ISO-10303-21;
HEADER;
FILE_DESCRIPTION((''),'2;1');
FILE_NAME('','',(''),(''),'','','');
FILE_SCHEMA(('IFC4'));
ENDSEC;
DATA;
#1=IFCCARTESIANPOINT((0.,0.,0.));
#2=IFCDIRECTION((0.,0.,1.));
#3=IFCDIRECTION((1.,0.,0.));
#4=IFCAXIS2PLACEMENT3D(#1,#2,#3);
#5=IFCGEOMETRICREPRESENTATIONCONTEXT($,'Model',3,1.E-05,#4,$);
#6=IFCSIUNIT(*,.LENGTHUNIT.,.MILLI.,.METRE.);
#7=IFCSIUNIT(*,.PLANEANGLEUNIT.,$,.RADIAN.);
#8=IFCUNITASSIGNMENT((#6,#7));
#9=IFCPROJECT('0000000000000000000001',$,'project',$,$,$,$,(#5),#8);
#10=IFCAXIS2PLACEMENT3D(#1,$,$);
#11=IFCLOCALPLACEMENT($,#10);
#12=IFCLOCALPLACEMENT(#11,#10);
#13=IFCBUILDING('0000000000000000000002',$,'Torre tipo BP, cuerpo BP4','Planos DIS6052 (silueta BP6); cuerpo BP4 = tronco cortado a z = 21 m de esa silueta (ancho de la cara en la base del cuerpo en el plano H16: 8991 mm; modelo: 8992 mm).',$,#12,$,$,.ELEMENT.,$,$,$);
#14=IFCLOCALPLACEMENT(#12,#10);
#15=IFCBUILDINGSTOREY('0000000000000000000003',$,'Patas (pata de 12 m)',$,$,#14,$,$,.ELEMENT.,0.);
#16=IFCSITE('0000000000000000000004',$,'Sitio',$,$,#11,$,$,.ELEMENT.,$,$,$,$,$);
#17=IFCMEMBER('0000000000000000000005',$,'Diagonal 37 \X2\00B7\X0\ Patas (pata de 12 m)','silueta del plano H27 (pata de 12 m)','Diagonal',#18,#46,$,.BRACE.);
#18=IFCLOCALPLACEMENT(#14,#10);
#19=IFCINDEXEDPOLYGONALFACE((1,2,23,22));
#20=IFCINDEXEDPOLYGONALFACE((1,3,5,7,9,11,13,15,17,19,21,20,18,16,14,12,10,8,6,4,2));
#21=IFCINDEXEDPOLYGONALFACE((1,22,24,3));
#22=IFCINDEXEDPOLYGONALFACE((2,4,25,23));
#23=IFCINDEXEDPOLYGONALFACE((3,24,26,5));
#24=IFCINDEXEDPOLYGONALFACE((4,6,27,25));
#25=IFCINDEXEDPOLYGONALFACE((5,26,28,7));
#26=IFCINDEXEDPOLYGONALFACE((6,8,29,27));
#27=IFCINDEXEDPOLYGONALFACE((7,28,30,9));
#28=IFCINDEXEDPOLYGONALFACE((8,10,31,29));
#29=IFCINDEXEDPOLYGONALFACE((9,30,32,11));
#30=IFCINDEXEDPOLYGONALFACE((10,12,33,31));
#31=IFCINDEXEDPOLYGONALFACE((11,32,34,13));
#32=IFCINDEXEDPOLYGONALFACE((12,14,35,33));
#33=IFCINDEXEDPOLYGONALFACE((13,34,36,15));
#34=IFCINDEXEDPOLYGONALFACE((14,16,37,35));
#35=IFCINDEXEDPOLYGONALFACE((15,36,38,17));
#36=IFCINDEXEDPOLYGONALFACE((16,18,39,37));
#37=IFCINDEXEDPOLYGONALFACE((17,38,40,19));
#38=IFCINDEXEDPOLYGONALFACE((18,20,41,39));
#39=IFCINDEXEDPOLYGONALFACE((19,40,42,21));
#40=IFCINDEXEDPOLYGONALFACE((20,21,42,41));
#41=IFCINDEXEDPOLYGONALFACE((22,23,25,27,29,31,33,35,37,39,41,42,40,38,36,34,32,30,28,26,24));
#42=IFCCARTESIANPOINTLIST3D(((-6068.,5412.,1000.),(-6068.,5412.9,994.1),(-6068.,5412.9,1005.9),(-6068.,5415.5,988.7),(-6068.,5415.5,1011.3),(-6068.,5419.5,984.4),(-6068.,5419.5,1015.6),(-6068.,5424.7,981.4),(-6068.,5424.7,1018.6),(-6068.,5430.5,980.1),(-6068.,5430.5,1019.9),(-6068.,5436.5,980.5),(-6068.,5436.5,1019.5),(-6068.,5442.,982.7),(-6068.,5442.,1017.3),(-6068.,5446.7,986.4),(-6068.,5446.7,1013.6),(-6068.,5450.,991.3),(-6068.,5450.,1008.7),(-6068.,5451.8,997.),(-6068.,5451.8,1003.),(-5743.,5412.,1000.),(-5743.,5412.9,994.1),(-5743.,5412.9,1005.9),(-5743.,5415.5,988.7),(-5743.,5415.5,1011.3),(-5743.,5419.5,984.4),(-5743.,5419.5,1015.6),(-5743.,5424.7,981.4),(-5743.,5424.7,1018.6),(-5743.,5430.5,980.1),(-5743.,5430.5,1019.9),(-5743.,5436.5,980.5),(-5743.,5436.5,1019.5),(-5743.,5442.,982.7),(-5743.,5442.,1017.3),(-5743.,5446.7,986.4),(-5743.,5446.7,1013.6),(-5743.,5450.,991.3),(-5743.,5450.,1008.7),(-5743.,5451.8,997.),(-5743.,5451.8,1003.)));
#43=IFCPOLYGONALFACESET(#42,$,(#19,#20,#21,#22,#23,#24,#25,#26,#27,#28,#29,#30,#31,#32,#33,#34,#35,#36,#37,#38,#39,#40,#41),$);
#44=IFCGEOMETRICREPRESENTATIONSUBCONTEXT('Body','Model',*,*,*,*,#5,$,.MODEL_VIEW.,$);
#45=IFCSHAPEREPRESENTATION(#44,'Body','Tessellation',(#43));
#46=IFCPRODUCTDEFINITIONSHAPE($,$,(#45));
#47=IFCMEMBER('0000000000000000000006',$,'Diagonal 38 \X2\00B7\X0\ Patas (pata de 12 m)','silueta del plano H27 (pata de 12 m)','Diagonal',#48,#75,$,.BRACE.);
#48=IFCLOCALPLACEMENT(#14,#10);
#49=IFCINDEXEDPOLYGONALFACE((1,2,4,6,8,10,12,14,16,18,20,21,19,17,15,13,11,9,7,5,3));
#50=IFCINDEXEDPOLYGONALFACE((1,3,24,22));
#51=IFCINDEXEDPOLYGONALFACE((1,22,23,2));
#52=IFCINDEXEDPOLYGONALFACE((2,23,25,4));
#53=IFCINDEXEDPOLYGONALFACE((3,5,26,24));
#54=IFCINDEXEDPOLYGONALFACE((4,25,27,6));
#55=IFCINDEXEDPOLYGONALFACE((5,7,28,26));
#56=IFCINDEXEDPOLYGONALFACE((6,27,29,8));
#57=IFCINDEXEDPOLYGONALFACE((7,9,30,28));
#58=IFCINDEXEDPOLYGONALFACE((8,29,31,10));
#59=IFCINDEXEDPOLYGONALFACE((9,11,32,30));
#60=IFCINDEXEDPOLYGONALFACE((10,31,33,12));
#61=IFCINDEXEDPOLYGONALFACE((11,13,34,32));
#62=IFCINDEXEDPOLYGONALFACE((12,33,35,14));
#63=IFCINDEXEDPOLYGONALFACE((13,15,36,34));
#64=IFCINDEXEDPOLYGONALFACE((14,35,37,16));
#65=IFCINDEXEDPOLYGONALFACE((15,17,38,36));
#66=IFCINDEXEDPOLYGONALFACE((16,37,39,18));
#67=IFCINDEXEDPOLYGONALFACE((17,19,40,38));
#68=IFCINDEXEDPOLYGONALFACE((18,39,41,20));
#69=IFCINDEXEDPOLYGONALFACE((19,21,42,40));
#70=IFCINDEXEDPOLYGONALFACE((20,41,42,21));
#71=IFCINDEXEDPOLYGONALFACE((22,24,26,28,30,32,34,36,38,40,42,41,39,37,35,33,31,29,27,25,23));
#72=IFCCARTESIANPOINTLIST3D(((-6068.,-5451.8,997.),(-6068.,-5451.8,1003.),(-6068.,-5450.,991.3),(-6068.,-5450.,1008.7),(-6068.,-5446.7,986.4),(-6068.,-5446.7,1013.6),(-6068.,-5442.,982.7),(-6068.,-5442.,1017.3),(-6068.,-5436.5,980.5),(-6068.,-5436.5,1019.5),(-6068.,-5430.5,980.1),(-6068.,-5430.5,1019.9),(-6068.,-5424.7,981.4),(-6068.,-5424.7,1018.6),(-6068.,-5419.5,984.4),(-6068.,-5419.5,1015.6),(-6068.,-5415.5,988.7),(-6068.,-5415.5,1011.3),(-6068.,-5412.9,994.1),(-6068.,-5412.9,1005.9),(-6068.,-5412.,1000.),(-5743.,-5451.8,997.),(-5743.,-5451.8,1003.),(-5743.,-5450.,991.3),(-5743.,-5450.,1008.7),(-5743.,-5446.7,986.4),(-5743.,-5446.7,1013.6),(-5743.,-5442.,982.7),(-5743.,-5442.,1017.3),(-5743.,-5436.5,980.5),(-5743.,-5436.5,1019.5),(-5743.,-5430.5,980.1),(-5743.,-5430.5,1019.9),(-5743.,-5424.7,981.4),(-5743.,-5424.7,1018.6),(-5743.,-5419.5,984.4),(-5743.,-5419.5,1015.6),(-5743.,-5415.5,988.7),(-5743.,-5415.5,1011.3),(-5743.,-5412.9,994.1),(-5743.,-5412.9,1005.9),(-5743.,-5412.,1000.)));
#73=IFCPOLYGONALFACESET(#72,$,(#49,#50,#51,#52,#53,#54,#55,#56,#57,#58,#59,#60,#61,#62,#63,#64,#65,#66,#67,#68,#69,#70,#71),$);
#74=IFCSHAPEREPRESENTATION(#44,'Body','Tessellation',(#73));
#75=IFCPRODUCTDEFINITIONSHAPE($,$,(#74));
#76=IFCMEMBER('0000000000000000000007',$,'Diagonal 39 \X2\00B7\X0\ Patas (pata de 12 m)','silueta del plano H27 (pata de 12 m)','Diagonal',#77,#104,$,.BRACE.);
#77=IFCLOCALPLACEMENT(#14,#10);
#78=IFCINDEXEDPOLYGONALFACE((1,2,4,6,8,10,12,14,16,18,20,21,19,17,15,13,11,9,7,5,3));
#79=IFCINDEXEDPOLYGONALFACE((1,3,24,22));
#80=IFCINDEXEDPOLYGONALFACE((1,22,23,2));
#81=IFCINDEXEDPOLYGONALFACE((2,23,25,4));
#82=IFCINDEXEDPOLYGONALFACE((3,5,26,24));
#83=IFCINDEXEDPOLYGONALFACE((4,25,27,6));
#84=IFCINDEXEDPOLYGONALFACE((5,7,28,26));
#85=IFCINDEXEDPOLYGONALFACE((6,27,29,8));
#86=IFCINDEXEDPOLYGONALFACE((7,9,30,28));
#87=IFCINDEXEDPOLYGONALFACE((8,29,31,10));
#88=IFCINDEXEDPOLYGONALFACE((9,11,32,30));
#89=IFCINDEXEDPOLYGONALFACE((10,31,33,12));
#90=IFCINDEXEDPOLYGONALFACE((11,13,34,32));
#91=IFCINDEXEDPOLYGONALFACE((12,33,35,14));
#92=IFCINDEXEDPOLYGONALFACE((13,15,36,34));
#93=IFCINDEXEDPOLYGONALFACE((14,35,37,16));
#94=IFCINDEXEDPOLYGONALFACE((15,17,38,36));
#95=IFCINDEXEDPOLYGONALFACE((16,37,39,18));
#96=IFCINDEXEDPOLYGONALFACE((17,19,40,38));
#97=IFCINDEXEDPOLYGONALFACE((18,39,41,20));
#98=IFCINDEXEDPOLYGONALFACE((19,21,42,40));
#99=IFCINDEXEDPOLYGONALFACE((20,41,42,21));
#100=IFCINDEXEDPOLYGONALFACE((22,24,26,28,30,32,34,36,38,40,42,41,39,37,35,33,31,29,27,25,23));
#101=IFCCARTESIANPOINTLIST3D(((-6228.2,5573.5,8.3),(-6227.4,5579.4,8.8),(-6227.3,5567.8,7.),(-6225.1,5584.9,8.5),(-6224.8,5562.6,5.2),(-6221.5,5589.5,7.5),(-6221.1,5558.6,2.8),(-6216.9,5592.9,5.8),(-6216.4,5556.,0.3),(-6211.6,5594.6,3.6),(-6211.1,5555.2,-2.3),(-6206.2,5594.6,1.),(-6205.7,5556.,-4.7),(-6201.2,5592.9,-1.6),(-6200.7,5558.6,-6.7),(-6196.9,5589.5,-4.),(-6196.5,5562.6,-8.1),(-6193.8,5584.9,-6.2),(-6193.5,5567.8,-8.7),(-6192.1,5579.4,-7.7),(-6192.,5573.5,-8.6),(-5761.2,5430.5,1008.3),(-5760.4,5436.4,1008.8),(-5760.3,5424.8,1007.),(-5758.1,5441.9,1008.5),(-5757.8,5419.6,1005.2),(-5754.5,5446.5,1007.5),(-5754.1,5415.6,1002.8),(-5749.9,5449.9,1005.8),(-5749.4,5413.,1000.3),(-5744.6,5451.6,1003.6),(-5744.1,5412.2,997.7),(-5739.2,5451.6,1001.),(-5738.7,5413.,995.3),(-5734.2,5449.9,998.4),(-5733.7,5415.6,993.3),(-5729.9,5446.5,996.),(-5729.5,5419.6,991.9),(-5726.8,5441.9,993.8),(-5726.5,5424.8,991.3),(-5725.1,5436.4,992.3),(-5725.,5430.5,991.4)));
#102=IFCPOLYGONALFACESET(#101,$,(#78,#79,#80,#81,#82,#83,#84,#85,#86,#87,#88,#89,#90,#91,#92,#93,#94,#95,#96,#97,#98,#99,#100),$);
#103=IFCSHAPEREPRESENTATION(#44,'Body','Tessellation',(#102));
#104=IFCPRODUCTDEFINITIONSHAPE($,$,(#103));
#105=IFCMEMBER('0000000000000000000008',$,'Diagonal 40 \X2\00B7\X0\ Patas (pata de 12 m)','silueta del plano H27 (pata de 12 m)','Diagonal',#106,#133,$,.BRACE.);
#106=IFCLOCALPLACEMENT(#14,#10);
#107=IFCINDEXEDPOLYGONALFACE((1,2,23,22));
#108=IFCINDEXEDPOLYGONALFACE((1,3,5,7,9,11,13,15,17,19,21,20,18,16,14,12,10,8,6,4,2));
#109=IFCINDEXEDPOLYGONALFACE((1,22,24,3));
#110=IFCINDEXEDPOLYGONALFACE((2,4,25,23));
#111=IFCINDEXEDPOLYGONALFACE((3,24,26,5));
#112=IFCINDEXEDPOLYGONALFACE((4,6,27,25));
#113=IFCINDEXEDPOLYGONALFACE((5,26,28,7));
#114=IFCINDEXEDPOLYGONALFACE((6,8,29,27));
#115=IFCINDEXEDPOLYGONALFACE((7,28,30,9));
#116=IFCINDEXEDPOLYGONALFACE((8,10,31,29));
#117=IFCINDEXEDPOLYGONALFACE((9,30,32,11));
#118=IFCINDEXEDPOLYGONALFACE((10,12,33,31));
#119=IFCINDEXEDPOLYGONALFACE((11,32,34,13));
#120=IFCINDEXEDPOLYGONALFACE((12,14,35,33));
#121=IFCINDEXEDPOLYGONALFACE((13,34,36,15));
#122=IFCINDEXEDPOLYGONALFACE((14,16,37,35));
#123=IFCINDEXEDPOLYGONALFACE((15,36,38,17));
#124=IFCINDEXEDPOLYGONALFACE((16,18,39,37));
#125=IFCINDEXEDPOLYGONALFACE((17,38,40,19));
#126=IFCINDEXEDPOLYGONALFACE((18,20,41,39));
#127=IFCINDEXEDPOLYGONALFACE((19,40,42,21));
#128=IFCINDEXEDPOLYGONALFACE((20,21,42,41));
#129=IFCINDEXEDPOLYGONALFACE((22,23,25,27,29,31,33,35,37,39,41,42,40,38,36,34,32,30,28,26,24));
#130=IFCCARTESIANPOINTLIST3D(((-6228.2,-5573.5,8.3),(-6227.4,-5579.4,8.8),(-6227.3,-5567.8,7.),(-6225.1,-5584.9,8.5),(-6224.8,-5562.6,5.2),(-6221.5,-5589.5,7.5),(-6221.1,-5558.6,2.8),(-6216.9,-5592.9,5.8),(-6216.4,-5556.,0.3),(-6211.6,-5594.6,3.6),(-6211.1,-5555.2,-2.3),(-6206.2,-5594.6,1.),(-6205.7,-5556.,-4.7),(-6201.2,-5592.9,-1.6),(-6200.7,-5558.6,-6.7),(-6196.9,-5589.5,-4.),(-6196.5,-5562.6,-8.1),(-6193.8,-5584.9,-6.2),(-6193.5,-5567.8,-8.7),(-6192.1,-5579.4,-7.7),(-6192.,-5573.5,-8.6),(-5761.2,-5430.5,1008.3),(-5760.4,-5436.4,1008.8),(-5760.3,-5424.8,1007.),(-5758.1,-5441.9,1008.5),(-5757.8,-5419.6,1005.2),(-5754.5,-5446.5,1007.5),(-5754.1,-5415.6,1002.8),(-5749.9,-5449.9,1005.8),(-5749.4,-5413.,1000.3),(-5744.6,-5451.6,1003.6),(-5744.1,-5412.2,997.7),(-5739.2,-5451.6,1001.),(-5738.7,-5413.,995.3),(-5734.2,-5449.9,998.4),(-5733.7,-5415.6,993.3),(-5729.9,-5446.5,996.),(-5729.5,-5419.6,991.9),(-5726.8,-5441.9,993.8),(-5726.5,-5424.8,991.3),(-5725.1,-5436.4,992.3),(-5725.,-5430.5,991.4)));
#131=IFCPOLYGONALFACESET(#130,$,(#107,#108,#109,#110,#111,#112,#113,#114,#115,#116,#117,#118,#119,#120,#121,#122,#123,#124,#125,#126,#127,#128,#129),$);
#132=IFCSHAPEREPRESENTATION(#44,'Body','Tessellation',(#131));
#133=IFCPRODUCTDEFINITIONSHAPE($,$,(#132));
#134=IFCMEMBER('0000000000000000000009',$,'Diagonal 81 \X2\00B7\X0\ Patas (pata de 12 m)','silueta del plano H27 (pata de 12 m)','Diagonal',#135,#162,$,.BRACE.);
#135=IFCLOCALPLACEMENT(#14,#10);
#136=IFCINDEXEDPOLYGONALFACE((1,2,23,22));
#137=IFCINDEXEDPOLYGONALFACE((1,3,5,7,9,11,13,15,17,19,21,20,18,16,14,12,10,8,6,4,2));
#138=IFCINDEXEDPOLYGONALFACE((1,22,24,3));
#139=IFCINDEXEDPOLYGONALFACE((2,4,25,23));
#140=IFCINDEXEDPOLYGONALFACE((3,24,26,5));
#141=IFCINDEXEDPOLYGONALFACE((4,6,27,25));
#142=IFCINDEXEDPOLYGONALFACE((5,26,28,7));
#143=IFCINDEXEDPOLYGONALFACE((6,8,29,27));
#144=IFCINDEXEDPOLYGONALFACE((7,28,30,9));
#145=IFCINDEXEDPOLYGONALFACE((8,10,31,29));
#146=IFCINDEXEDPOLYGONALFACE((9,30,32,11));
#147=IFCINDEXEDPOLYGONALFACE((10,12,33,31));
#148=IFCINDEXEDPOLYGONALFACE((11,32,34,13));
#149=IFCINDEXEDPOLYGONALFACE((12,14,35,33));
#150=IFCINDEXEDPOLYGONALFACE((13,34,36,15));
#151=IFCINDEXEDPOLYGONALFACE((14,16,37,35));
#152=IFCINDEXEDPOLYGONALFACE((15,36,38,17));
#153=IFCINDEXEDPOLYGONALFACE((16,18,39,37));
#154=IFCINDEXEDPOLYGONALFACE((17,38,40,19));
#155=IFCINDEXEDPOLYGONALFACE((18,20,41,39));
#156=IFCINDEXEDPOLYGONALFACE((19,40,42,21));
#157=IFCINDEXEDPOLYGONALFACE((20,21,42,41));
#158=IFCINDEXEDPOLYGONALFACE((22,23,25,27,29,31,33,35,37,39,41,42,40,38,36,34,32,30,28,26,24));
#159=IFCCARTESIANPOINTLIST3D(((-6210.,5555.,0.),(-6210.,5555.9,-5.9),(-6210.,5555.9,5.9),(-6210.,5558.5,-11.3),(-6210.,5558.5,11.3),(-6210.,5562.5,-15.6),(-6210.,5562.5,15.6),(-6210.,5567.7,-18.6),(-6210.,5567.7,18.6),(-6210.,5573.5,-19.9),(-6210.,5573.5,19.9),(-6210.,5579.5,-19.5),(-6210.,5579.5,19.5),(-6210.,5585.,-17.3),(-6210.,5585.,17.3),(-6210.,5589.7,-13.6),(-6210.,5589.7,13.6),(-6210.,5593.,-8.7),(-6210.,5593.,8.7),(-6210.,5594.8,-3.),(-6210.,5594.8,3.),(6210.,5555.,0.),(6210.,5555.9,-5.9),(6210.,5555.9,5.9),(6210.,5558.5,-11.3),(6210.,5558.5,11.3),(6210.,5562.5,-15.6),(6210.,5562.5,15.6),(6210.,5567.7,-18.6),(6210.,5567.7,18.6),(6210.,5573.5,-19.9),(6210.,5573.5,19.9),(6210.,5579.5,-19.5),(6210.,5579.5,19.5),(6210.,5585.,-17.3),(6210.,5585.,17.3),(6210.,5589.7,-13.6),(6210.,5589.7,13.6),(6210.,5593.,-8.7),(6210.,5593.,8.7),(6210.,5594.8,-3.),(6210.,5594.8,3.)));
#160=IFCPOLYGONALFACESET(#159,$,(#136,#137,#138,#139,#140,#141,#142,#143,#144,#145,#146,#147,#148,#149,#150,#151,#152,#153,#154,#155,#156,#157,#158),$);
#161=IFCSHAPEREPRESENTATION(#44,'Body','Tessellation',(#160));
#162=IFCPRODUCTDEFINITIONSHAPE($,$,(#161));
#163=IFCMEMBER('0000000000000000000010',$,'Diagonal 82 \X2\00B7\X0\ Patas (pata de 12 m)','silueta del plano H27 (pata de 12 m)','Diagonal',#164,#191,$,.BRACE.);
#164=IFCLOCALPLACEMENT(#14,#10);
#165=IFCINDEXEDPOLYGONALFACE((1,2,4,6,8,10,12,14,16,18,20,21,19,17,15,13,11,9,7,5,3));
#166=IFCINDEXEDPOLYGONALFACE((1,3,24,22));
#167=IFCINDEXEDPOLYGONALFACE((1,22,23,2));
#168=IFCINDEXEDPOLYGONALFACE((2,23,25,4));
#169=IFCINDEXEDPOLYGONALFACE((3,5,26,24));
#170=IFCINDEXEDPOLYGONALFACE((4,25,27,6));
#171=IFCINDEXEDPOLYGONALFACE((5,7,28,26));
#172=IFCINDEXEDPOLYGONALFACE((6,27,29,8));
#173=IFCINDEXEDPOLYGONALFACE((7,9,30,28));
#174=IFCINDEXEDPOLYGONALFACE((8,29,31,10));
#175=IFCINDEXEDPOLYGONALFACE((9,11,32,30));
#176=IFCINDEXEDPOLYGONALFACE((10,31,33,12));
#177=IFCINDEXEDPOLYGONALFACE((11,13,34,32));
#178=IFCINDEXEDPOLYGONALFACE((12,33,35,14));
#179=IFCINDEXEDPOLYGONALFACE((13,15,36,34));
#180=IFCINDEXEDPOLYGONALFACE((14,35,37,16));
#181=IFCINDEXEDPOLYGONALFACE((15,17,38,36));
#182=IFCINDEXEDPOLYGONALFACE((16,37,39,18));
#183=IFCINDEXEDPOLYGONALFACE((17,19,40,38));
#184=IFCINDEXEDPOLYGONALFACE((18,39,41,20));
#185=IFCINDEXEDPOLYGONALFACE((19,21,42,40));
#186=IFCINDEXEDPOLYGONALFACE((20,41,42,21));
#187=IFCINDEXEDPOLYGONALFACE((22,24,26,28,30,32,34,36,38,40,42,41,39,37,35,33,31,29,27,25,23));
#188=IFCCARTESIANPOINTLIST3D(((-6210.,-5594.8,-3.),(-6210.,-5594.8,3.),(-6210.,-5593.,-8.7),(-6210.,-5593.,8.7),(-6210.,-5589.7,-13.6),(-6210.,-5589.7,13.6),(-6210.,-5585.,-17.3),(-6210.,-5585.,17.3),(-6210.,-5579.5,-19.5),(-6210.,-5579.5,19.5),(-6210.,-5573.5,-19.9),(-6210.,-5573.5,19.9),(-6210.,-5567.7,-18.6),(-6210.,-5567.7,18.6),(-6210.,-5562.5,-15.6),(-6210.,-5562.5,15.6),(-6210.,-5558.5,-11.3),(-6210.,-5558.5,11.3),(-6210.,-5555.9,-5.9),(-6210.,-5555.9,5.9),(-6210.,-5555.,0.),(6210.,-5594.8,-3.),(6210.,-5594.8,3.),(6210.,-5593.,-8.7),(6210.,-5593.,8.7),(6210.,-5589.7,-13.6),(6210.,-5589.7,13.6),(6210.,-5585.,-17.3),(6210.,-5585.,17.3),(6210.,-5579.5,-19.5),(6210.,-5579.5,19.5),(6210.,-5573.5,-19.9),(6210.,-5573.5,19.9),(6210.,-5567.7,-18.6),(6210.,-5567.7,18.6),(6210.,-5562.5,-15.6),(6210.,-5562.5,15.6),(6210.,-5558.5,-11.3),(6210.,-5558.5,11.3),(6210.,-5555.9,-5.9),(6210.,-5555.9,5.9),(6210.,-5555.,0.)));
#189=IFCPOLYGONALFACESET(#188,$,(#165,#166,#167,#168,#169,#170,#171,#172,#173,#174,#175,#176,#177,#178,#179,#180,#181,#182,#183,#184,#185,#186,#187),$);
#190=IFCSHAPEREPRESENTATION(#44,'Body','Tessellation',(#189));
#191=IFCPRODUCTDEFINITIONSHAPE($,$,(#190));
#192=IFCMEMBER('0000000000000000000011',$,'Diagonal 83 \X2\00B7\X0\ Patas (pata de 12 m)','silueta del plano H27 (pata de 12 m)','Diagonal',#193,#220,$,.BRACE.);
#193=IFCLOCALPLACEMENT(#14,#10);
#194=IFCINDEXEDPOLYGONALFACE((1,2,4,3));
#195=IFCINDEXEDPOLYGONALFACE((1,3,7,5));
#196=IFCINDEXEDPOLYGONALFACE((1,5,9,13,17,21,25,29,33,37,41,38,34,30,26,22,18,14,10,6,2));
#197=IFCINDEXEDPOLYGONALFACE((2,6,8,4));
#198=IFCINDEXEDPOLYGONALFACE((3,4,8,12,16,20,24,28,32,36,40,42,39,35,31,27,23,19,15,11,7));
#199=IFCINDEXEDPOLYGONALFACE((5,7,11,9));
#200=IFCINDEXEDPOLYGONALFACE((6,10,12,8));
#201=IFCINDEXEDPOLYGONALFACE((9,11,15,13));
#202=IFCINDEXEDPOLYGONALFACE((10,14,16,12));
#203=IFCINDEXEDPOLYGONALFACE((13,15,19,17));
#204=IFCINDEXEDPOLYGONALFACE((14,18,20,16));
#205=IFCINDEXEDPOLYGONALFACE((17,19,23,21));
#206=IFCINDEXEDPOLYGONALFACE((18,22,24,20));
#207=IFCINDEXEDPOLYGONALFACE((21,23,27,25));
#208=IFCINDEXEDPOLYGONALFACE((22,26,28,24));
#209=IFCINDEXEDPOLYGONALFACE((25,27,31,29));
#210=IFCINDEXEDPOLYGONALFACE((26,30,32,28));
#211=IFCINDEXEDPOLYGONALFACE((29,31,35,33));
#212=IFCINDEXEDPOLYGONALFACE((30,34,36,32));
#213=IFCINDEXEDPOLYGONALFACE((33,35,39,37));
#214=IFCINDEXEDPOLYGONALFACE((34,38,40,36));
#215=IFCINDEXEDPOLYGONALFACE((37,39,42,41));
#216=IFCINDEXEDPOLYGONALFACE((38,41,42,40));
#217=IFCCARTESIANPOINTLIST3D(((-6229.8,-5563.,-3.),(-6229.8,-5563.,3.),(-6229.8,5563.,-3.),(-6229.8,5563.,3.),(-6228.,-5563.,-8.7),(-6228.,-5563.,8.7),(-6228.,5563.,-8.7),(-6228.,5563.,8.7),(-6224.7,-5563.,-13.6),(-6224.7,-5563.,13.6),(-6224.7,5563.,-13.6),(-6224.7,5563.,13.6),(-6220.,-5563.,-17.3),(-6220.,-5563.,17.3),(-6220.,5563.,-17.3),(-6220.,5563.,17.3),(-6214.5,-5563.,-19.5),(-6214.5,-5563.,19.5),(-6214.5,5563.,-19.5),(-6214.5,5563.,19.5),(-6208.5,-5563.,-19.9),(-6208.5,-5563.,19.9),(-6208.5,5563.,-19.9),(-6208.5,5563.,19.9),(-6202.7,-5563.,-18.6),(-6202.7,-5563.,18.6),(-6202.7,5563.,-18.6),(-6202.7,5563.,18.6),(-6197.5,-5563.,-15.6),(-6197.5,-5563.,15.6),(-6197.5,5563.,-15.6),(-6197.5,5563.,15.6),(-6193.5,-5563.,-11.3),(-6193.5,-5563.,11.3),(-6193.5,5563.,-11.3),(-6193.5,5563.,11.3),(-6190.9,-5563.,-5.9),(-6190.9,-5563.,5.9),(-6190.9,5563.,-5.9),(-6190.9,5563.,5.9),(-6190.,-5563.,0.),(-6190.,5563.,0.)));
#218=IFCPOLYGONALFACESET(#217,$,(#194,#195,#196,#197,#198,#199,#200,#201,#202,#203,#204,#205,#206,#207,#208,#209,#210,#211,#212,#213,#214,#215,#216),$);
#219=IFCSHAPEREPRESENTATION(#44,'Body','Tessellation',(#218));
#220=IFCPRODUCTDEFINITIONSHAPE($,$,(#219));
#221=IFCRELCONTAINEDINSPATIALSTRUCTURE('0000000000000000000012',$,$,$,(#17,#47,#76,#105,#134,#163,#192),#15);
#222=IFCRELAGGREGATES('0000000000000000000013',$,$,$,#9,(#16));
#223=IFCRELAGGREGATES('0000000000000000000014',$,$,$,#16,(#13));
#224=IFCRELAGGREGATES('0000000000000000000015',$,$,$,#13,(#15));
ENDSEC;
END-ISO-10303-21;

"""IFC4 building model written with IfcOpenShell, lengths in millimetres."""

from ifc_helpers import new_model, si_unit, frame, origin, origin_with_axes, place, context, subcontext, project, spatial, circle, extrude, element, save


model = new_model("IFC4")

# Units and contexts
model_context = context("Model", 3, precision=1e-05, world=origin_with_axes())
body_context = subcontext(model_context, "Body", "Model", "MODEL_VIEW")
ifc_project = project(units=[si_unit("LENGTHUNIT", "METRE", prefix="MILLI"), si_unit("PLANEANGLEUNIT", "RADIAN")], contexts=[model_context])

# Site, building, storey
site_placement = place(None, origin())
site = spatial("IfcSite", under=ifc_project, at=site_placement, Name="Sitio", CompositionType="ELEMENT")
building_placement = place(site_placement, origin())
building = spatial("IfcBuilding", under=site, at=building_placement, Name="Torre tipo BP, cuerpo BP4", Description="Planos DIS6052 (silueta BP6); cuerpo BP4 = tronco cortado a z = 21 m de esa silueta (ancho de la cara en la base del cuerpo en el plano H16: 8991 mm; modelo: 8992 mm).", CompositionType="ELEMENT")
storey_placement = place(building_placement, origin())
storey = spatial("IfcBuildingStorey", under=building, at=storey_placement, Name="Patas (pata de 12 m)", CompositionType="ELEMENT", Elevation=0.0)

# Members
for number, where, z_axis, x_axis, name in (
    (1, (-6068.0, 5432.0, 1000.0), (1.0, 0.0, 0.0), (0.0, -1.0, 0.0), "Diagonal 37 · Patas (pata de 12 m)"),
    (2, (-6068.0, -5432.0, 1000.0), (1.0, 0.0, 0.0), (0.0, 1.0, 0.0), "Diagonal 38 · Patas (pata de 12 m)"),
):
    element("IfcMember", number, at=place(storey_placement, frame(where, z_axis=z_axis, x_axis=x_axis)), inside=storey, Name=name, Description="silueta del plano H27 (pata de 12 m)", ObjectType="Diagonal", PredefinedType="BRACE", context=body_context, shape_type="SweptSolid", body=[
        extrude(circle(Radius=20.0), None, (0.0, 0.0, 1.0), 325.0),
    ])
for number, where, z_axis, x_axis, name in (
    (3, (-6210.0, 5575.0, 0.0), (0.419626, -0.128494, 0.898556), (-0.05437, -0.99171, -0.116424), "Diagonal 39 · Patas (pata de 12 m)"),
    (4, (-6210.0, -5575.0, 0.0), (0.419626, 0.128494, 0.898556), (-0.05437, 0.99171, -0.116424), "Diagonal 40 · Patas (pata de 12 m)"),
):
    element("IfcMember", number, at=place(storey_placement, frame(where, z_axis=z_axis, x_axis=x_axis)), inside=storey, Name=name, Description="silueta del plano H27 (pata de 12 m)", ObjectType="Diagonal", PredefinedType="BRACE", context=body_context, shape_type="SweptSolid", body=[
        extrude(circle(Radius=20.0), None, (0.0, 0.0, 1.0), 1112.9),
    ])
for number, where, z_axis, x_axis, name in (
    (5, (-6210.0, 5575.0, 0.0), (1.0, 0.0, 0.0), (0.0, -1.0, 0.0), "Diagonal 81 · Patas (pata de 12 m)"),
    (6, (-6210.0, -5575.0, 0.0), (1.0, 0.0, 0.0), (0.0, 1.0, 0.0), "Diagonal 82 · Patas (pata de 12 m)"),
):
    element("IfcMember", number, at=place(storey_placement, frame(where, z_axis=z_axis, x_axis=x_axis)), inside=storey, Name=name, Description="silueta del plano H27 (pata de 12 m)", ObjectType="Diagonal", PredefinedType="BRACE", context=body_context, shape_type="SweptSolid", body=[
        extrude(circle(Radius=20.0), None, (0.0, 0.0, 1.0), 12420.0),
    ])
member_1_placement = place(storey_placement, frame((-6210.0, 5563.0, 0.0), z_axis=(0.0, -1.0, 0.0), x_axis=(1.0, 0.0, 0.0)))
element("IfcMember", 7, at=member_1_placement, inside=storey, Name="Diagonal 83 · Patas (pata de 12 m)", Description="silueta del plano H27 (pata de 12 m)", ObjectType="Diagonal", PredefinedType="BRACE", context=body_context, shape_type="SweptSolid", body=[
    extrude(circle(Radius=20.0), None, (0.0, 0.0, 1.0), 11126.0),
])

save(model, "model.ifc")
